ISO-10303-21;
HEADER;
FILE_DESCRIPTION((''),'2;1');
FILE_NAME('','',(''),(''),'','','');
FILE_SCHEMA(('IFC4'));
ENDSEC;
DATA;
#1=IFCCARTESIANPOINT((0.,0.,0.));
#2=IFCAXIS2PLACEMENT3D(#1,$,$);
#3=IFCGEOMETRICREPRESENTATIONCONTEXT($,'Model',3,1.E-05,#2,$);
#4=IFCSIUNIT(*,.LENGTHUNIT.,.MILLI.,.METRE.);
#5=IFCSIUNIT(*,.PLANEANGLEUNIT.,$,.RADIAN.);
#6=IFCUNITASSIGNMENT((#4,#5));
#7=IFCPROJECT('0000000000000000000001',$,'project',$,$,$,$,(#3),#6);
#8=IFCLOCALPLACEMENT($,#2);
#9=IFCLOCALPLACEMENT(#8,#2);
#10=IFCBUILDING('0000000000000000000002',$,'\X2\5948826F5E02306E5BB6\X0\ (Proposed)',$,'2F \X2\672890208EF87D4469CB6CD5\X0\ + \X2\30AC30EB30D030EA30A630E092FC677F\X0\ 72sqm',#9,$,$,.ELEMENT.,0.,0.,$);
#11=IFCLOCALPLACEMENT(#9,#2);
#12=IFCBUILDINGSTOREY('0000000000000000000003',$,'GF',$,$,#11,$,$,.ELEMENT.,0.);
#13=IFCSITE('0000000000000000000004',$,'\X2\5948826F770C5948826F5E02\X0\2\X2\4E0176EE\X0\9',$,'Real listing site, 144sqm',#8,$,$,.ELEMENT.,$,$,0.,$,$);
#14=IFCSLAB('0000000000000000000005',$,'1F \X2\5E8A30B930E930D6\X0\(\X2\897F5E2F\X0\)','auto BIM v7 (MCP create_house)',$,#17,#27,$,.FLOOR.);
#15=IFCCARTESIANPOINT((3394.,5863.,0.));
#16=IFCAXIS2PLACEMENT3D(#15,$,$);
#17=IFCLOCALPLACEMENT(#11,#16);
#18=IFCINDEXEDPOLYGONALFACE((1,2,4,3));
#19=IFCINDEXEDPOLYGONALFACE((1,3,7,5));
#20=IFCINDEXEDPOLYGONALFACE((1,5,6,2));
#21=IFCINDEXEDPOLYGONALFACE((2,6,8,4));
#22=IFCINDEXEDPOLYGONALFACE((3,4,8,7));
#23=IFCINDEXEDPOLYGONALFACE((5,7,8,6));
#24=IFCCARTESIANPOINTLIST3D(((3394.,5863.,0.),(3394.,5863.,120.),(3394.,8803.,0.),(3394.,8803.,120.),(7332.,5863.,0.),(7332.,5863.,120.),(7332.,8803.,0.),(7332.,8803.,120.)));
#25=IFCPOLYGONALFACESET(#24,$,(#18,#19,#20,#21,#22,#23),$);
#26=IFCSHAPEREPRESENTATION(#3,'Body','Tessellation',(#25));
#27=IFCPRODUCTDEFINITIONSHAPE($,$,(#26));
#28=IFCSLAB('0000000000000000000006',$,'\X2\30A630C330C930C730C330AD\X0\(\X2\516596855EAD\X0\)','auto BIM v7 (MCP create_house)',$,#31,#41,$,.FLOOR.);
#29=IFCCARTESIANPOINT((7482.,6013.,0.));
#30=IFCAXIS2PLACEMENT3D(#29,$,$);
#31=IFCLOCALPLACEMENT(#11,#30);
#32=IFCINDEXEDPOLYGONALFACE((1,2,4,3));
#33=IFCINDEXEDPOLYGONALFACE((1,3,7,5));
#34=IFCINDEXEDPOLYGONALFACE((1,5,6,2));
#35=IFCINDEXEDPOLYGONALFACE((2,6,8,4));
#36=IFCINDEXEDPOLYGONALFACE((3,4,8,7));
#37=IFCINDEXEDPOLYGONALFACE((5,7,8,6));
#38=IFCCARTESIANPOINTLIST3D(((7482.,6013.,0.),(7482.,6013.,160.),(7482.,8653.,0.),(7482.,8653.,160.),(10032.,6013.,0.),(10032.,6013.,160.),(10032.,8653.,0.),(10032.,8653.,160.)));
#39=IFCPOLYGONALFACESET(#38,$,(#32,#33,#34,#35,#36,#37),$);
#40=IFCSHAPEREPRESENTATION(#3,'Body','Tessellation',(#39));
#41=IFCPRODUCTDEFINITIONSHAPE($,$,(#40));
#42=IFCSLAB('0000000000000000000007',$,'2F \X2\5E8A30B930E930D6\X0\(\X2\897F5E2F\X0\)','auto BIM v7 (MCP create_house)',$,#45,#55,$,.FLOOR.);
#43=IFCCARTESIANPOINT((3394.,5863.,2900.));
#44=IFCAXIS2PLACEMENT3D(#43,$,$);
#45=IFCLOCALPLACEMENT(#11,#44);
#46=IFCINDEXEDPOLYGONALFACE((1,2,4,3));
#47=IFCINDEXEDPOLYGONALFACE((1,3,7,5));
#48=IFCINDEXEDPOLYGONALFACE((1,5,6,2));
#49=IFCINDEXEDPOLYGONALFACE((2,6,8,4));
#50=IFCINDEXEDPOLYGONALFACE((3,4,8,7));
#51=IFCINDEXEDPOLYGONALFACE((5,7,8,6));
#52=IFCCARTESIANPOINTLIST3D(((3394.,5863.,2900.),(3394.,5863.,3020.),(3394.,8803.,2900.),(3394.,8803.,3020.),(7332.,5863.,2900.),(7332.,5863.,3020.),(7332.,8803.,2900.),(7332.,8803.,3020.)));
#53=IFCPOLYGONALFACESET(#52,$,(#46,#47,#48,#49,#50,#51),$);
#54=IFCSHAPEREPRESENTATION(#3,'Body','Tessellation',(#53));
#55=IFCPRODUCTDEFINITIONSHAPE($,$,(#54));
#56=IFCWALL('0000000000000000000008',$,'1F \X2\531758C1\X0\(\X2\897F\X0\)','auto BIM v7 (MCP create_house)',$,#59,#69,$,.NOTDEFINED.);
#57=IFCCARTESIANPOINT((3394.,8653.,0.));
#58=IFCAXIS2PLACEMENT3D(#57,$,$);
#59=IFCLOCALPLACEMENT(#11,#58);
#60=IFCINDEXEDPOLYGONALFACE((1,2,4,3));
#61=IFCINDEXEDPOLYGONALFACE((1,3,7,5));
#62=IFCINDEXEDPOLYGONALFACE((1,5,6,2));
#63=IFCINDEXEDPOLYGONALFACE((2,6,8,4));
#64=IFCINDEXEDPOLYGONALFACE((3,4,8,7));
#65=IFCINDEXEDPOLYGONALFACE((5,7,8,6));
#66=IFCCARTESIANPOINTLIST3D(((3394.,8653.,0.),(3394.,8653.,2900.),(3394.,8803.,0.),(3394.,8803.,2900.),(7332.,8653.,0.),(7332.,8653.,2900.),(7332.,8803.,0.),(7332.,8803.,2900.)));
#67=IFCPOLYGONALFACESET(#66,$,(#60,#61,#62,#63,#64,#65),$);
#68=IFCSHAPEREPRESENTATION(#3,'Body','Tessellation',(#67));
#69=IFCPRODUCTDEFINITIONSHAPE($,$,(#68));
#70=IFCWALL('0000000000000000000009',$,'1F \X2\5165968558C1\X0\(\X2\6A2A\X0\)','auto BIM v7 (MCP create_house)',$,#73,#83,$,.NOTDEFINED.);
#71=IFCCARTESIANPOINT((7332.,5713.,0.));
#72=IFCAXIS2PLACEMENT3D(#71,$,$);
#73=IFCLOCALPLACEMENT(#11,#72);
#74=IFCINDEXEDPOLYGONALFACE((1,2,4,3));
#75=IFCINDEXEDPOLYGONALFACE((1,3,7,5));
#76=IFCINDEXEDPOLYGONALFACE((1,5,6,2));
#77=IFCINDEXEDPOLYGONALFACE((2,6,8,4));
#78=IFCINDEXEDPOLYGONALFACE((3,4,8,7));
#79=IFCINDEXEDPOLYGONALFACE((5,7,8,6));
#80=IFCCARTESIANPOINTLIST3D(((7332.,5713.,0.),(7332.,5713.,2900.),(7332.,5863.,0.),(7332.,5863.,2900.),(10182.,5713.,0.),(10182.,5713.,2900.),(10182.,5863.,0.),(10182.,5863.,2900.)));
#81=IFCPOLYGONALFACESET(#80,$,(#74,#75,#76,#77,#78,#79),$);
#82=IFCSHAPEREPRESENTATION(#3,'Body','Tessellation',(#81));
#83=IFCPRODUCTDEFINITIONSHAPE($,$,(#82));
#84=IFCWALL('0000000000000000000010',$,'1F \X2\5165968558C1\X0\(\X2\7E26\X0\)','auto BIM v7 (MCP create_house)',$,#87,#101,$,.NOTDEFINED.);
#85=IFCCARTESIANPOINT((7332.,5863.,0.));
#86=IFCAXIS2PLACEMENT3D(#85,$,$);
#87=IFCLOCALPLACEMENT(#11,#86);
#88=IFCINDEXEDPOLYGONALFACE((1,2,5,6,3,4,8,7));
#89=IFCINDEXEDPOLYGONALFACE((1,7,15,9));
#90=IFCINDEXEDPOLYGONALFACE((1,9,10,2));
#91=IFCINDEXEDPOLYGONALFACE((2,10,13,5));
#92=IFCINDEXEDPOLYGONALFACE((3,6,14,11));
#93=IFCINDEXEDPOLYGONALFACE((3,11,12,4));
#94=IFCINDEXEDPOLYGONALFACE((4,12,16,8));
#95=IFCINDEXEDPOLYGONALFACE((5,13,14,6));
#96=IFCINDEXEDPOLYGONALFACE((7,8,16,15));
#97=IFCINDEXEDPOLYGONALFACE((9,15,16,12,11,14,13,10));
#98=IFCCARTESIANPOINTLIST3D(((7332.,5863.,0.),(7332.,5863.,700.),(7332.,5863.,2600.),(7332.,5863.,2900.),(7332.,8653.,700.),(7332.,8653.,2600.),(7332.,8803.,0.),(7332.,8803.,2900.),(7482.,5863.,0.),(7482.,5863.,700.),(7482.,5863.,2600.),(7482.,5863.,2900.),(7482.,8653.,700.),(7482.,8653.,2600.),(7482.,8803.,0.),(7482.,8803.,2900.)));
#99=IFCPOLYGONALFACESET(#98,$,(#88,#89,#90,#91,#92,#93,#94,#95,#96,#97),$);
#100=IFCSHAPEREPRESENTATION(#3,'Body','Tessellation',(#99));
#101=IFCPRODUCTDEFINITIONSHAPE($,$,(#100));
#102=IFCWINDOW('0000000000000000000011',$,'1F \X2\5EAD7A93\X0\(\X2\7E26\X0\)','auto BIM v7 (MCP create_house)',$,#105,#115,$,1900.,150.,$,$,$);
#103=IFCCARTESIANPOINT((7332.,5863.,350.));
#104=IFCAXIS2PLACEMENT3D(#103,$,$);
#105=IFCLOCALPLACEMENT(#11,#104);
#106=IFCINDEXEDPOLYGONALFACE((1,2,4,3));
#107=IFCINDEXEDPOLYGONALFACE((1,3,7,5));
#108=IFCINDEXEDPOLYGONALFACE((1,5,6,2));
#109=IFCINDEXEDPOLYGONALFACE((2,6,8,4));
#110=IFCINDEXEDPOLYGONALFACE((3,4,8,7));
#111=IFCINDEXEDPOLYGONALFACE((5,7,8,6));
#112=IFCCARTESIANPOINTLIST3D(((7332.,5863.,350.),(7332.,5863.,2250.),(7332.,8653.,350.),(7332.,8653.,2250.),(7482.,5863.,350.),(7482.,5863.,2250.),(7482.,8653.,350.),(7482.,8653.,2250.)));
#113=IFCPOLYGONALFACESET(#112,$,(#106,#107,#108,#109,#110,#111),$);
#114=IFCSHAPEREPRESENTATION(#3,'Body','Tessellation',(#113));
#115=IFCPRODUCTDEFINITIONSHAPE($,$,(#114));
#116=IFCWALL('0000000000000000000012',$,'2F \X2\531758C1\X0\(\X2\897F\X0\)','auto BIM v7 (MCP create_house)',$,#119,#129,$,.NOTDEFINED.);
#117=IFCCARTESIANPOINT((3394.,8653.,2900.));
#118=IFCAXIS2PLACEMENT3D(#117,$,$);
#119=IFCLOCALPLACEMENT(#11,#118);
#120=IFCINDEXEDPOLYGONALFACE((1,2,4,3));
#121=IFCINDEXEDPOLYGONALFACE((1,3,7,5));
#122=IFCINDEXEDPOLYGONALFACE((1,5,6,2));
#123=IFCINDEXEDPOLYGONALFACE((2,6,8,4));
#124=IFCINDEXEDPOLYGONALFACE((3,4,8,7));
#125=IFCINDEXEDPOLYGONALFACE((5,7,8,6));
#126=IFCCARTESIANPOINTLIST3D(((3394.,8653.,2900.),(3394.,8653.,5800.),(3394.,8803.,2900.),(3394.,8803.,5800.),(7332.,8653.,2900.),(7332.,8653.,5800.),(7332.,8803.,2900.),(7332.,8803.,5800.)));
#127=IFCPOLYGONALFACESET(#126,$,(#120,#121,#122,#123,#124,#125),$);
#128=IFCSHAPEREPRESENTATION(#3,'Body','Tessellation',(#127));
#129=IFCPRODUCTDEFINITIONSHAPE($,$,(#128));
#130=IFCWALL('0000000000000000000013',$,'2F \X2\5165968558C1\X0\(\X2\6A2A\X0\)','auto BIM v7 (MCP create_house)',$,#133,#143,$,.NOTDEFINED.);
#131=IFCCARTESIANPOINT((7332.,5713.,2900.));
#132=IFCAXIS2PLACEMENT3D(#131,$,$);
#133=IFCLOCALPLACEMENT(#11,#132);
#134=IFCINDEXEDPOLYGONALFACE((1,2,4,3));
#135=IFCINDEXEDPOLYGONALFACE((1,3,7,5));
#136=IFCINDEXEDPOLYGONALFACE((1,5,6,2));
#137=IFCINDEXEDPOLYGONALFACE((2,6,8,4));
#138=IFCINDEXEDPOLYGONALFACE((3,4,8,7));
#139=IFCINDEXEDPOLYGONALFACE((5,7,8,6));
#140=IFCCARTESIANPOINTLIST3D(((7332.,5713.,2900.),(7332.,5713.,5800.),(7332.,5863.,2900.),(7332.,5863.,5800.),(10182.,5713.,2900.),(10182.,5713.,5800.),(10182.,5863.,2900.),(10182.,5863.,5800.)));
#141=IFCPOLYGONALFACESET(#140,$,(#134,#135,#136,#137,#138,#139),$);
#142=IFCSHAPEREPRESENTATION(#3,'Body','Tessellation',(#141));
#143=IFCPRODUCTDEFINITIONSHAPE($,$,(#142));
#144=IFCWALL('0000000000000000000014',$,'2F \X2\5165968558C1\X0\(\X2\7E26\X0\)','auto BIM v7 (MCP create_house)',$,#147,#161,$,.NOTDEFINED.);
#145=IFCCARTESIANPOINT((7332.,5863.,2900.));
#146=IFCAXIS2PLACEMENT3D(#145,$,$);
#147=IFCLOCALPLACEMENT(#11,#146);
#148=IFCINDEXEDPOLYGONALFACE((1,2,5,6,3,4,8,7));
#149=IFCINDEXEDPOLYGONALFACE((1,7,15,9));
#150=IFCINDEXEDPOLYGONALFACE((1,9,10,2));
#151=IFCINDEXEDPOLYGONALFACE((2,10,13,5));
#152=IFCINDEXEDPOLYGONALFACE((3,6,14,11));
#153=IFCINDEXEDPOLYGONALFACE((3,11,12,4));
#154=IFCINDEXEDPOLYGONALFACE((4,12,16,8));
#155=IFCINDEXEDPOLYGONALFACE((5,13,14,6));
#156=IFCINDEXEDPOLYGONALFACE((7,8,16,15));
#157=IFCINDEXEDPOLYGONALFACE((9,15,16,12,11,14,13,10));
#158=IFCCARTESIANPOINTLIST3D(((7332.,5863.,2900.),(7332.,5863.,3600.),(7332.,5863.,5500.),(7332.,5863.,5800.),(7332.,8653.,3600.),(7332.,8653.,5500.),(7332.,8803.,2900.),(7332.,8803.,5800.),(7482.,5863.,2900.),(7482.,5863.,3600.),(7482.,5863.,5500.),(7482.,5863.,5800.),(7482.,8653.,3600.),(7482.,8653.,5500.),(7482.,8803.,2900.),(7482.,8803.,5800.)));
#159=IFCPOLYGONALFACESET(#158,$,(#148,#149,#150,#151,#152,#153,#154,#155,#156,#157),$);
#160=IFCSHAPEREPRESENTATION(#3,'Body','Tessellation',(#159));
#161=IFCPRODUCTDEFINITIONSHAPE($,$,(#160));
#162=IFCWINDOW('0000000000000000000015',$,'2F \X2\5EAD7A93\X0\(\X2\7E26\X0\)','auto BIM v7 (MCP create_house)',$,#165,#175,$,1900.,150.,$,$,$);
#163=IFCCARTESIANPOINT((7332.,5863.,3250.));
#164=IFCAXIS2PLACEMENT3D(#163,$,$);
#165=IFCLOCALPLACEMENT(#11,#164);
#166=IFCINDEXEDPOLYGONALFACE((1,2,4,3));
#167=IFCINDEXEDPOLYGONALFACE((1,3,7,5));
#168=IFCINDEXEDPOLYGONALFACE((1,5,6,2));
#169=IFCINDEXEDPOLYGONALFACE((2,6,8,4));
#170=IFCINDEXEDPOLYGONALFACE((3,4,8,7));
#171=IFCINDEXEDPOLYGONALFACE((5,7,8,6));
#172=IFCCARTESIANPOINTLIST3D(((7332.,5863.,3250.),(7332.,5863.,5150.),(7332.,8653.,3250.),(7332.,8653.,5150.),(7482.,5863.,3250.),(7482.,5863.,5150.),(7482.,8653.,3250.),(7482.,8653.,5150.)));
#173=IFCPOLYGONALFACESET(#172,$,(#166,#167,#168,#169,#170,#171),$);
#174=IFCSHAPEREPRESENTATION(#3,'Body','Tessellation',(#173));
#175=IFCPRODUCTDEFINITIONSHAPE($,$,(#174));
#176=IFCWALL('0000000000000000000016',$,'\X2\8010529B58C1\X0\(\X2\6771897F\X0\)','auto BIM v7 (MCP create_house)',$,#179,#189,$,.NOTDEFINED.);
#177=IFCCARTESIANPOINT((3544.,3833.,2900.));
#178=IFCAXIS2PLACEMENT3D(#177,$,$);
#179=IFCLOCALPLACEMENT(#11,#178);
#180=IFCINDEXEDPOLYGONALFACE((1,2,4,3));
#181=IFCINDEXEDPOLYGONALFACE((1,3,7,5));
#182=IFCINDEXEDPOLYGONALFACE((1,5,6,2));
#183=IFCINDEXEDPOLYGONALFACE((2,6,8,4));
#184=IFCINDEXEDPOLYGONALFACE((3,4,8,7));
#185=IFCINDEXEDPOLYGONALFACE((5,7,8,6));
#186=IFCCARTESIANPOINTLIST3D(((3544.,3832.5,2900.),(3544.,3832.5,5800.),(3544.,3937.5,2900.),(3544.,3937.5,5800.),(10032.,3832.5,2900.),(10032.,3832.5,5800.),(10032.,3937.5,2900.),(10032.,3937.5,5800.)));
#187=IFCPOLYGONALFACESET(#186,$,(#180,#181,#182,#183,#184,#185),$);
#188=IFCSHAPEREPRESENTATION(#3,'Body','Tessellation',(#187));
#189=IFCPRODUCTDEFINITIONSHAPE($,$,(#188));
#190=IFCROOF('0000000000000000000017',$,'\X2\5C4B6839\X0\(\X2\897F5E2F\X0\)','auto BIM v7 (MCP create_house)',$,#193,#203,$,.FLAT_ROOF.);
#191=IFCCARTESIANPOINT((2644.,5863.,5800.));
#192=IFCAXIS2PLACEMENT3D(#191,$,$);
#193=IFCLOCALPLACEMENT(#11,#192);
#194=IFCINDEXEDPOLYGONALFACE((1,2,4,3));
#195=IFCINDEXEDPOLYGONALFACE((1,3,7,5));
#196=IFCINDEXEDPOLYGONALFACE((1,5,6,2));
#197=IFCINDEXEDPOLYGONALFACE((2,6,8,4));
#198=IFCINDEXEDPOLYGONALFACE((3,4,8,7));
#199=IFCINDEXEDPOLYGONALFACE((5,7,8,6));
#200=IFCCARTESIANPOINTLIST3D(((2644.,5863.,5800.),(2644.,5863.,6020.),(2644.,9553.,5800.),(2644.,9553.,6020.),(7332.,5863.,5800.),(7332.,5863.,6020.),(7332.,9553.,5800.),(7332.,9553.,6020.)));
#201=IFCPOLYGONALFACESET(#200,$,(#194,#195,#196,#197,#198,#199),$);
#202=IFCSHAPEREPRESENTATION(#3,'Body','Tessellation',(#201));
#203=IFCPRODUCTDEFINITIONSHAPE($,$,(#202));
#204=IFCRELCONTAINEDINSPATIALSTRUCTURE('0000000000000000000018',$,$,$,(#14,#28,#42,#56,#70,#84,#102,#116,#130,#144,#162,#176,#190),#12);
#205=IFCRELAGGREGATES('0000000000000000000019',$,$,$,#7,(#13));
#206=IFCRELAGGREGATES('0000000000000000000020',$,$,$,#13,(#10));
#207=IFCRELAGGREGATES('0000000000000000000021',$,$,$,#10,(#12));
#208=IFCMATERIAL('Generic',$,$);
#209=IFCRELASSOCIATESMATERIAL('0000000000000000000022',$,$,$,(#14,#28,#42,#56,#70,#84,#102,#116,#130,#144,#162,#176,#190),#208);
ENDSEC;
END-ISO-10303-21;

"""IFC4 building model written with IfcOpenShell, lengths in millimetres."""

from ifc_helpers import new_model, si_unit, frame, frame_2d, origin, place, context, project, spatial, rectangle, extrude, material, element, fill, save


model = new_model("IFC4")

# Units and contexts
model_context = context("Model", 3, precision=1e-05, world=origin())
ifc_project = project(units=[si_unit("LENGTHUNIT", "METRE", prefix="MILLI"), si_unit("PLANEANGLEUNIT", "RADIAN")], contexts=[model_context])

# Site, building, storey
site_placement = place(None, origin())
site = spatial("IfcSite", under=ifc_project, at=site_placement, Name="奈良県奈良市2丁目9", ObjectType="Real listing site, 144sqm", CompositionType="ELEMENT", RefElevation=0.0)
building_placement = place(site_placement, origin())
building = spatial("IfcBuilding", under=site, at=building_placement, Name="奈良市の家 (Proposed)", ObjectType="2F 木造軸組構法 + ガルバリウム鋼板 72sqm", CompositionType="ELEMENT", ElevationOfRefHeight=0.0, ElevationOfTerrain=0.0)
storey_placement = place(building_placement, origin())
storey = spatial("IfcBuildingStorey", under=building, at=storey_placement, Name="GF", CompositionType="ELEMENT", Elevation=0.0)

# Slabs
ifc_material = material(Name="Generic")
slab_1_placement = place(storey_placement, frame((3394.0, 5863.0, 0.0)))
element("IfcSlab", 1, at=slab_1_placement, inside=storey, material=ifc_material, Name="1F 床スラブ(西帯)", Description="auto BIM v7 (MCP create_house)", PredefinedType="FLOOR", context=model_context, shape_type="SweptSolid", body=[
    extrude(rectangle(XDim=3938.0, YDim=2940.0, at=frame_2d((1969.0, 1470.0))), frame((3394.0, 5863.0, 0.0)), (0.0, 0.0, 1.0), 120.0),
])
slab_2_placement = place(storey_placement, frame((7482.0, 6013.0, 0.0)))
element("IfcSlab", 2, at=slab_2_placement, inside=storey, material=ifc_material, Name="ウッドデッキ(入隅庭)", Description="auto BIM v7 (MCP create_house)", PredefinedType="FLOOR", context=model_context, shape_type="SweptSolid", body=[
    extrude(rectangle(XDim=2550.0, YDim=2640.0, at=frame_2d((1275.0, 1320.0))), frame((7482.0, 6013.0, 0.0)), (0.0, 0.0, 1.0), 160.0),
])
slab_3_placement = place(storey_placement, frame((3394.0, 5863.0, 2900.0)))
element("IfcSlab", 3, at=slab_3_placement, inside=storey, material=ifc_material, Name="2F 床スラブ(西帯)", Description="auto BIM v7 (MCP create_house)", PredefinedType="FLOOR", context=model_context, shape_type="SweptSolid", body=[
    extrude(rectangle(XDim=3938.0, YDim=2940.0, at=frame_2d((1969.0, 1470.0))), frame((3394.0, 5863.0, 2900.0)), (0.0, 0.0, 1.0), 120.0),
])

# Walls
wall_1_placement = place(storey_placement, frame((3394.0, 8653.0, 0.0)))
element("IfcWall", 4, at=wall_1_placement, inside=storey, material=ifc_material, Name="1F 北壁(西)", Description="auto BIM v7 (MCP create_house)", PredefinedType="NOTDEFINED", context=model_context, shape_type="SweptSolid", body=[
    extrude(rectangle(XDim=3938.0, YDim=150.0, at=frame_2d((1969.0, 75.0))), frame((3394.0, 8653.0, 0.0)), (0.0, 0.0, 1.0), 2900.0),
])
wall_2_placement = place(storey_placement, frame((7332.0, 5713.0, 0.0)))
element("IfcWall", 5, at=wall_2_placement, inside=storey, material=ifc_material, Name="1F 入隅壁(横)", Description="auto BIM v7 (MCP create_house)", PredefinedType="NOTDEFINED", context=model_context, shape_type="SweptSolid", body=[
    extrude(rectangle(XDim=2850.0, YDim=150.0, at=frame_2d((1425.0, 75.0))), frame((7332.0, 5713.0, 0.0)), (0.0, 0.0, 1.0), 2900.0),
])

# Wall, opening, window
wall_3_placement = place(storey_placement, frame((7332.0, 5863.0, 0.0)))
wall_3 = element("IfcWall", 6, at=wall_3_placement, inside=storey, material=ifc_material, Name="1F 入隅壁(縦)", Description="auto BIM v7 (MCP create_house)", PredefinedType="NOTDEFINED", context=model_context, shape_type="SweptSolid", body=[
    extrude(rectangle(XDim=150.0, YDim=2940.0, at=frame_2d((75.0, 1470.0))), frame((7332.0, 5863.0, 0.0)), (0.0, 0.0, 1.0), 2900.0),
])
opening_1_placement = place(storey_placement, frame((7332.0, 5863.0, 350.0)))
opening_1 = element("IfcOpeningElement", 7, at=opening_1_placement, cuts=wall_3, PredefinedType="NOTDEFINED", context=model_context, shape_type="SweptSolid", body=[
    extrude(rectangle(XDim=150.0, YDim=2790.0, at=frame_2d((75.0, 1395.0))), frame((7332.0, 5863.0, 350.0)), (0.0, 0.0, 1.0), 1900.0),
])
window_1_placement = place(storey_placement, frame((7332.0, 5863.0, 350.0)))
window_1 = element("IfcWindow", 8, at=window_1_placement, inside=storey, material=ifc_material, Name="1F 庭窓(縦)", Description="auto BIM v7 (MCP create_house)", OverallHeight=1900.0, OverallWidth=150.0, context=model_context, shape_type="SweptSolid", body=[
    extrude(rectangle(XDim=150.0, YDim=2790.0, at=frame_2d((75.0, 1395.0))), frame((7332.0, 5863.0, 350.0)), (0.0, 0.0, 1.0), 1900.0),
])
fill(opening_1, window_1)

# Walls
wall_4_placement = place(storey_placement, frame((3394.0, 8653.0, 2900.0)))
element("IfcWall", 9, at=wall_4_placement, inside=storey, material=ifc_material, Name="2F 北壁(西)", Description="auto BIM v7 (MCP create_house)", PredefinedType="NOTDEFINED", context=model_context, shape_type="SweptSolid", body=[
    extrude(rectangle(XDim=3938.0, YDim=150.0, at=frame_2d((1969.0, 75.0))), frame((3394.0, 8653.0, 2900.0)), (0.0, 0.0, 1.0), 2900.0),
])
wall_5_placement = place(storey_placement, frame((7332.0, 5713.0, 2900.0)))
element("IfcWall", 10, at=wall_5_placement, inside=storey, material=ifc_material, Name="2F 入隅壁(横)", Description="auto BIM v7 (MCP create_house)", PredefinedType="NOTDEFINED", context=model_context, shape_type="SweptSolid", body=[
    extrude(rectangle(XDim=2850.0, YDim=150.0, at=frame_2d((1425.0, 75.0))), frame((7332.0, 5713.0, 2900.0)), (0.0, 0.0, 1.0), 2900.0),
])

# Wall, opening, window
wall_6_placement = place(storey_placement, frame((7332.0, 5863.0, 2900.0)))
wall_6 = element("IfcWall", 11, at=wall_6_placement, inside=storey, material=ifc_material, Name="2F 入隅壁(縦)", Description="auto BIM v7 (MCP create_house)", PredefinedType="NOTDEFINED", context=model_context, shape_type="SweptSolid", body=[
    extrude(rectangle(XDim=150.0, YDim=2940.0, at=frame_2d((75.0, 1470.0))), frame((7332.0, 5863.0, 2900.0)), (0.0, 0.0, 1.0), 2900.0),
])
opening_2_placement = place(storey_placement, frame((7332.0, 5863.0, 3250.0)))
opening_2 = element("IfcOpeningElement", 12, at=opening_2_placement, cuts=wall_6, PredefinedType="NOTDEFINED", context=model_context, shape_type="SweptSolid", body=[
    extrude(rectangle(XDim=150.0, YDim=2790.0, at=frame_2d((75.0, 1395.0))), frame((7332.0, 5863.0, 3250.0)), (0.0, 0.0, 1.0), 1900.0),
])
window_2_placement = place(storey_placement, frame((7332.0, 5863.0, 3250.0)))
window_2 = element("IfcWindow", 13, at=window_2_placement, inside=storey, material=ifc_material, Name="2F 庭窓(縦)", Description="auto BIM v7 (MCP create_house)", OverallHeight=1900.0, OverallWidth=150.0, context=model_context, shape_type="SweptSolid", body=[
    extrude(rectangle(XDim=150.0, YDim=2790.0, at=frame_2d((75.0, 1395.0))), frame((7332.0, 5863.0, 3250.0)), (0.0, 0.0, 1.0), 1900.0),
])
fill(opening_2, window_2)

# Wall
wall_7_placement = place(storey_placement, frame((3544.0, 3833.0, 2900.0)))
element("IfcWall", 14, at=wall_7_placement, inside=storey, material=ifc_material, Name="耐力壁(東西)", Description="auto BIM v7 (MCP create_house)", PredefinedType="NOTDEFINED", context=model_context, shape_type="SweptSolid", body=[
    extrude(rectangle(XDim=6488.0, YDim=105.0, at=frame_2d((3244.0, 52.0))), frame((3544.0, 3833.0, 2900.0)), (0.0, 0.0, 1.0), 2900.0),
])

# Roof
for number, where, name in (
    (15, (2644.0, 5863.0, 5800.0), "屋根(西帯)"),
):
    element("IfcRoof", number, at=place(storey_placement, frame(where)), inside=storey, material=ifc_material, Name=name, Description="auto BIM v7 (MCP create_house)", PredefinedType="FLAT_ROOF", context=model_context, shape_type="SweptSolid", body=[
        extrude(rectangle(XDim=4688.0, YDim=3690.0, at=frame_2d((2344.0, 1845.0))), frame((2644.0, 5863.0, 5800.0)), (0.0, 0.0, 1.0), 220.0),
    ])

save(model, "model.ifc")
